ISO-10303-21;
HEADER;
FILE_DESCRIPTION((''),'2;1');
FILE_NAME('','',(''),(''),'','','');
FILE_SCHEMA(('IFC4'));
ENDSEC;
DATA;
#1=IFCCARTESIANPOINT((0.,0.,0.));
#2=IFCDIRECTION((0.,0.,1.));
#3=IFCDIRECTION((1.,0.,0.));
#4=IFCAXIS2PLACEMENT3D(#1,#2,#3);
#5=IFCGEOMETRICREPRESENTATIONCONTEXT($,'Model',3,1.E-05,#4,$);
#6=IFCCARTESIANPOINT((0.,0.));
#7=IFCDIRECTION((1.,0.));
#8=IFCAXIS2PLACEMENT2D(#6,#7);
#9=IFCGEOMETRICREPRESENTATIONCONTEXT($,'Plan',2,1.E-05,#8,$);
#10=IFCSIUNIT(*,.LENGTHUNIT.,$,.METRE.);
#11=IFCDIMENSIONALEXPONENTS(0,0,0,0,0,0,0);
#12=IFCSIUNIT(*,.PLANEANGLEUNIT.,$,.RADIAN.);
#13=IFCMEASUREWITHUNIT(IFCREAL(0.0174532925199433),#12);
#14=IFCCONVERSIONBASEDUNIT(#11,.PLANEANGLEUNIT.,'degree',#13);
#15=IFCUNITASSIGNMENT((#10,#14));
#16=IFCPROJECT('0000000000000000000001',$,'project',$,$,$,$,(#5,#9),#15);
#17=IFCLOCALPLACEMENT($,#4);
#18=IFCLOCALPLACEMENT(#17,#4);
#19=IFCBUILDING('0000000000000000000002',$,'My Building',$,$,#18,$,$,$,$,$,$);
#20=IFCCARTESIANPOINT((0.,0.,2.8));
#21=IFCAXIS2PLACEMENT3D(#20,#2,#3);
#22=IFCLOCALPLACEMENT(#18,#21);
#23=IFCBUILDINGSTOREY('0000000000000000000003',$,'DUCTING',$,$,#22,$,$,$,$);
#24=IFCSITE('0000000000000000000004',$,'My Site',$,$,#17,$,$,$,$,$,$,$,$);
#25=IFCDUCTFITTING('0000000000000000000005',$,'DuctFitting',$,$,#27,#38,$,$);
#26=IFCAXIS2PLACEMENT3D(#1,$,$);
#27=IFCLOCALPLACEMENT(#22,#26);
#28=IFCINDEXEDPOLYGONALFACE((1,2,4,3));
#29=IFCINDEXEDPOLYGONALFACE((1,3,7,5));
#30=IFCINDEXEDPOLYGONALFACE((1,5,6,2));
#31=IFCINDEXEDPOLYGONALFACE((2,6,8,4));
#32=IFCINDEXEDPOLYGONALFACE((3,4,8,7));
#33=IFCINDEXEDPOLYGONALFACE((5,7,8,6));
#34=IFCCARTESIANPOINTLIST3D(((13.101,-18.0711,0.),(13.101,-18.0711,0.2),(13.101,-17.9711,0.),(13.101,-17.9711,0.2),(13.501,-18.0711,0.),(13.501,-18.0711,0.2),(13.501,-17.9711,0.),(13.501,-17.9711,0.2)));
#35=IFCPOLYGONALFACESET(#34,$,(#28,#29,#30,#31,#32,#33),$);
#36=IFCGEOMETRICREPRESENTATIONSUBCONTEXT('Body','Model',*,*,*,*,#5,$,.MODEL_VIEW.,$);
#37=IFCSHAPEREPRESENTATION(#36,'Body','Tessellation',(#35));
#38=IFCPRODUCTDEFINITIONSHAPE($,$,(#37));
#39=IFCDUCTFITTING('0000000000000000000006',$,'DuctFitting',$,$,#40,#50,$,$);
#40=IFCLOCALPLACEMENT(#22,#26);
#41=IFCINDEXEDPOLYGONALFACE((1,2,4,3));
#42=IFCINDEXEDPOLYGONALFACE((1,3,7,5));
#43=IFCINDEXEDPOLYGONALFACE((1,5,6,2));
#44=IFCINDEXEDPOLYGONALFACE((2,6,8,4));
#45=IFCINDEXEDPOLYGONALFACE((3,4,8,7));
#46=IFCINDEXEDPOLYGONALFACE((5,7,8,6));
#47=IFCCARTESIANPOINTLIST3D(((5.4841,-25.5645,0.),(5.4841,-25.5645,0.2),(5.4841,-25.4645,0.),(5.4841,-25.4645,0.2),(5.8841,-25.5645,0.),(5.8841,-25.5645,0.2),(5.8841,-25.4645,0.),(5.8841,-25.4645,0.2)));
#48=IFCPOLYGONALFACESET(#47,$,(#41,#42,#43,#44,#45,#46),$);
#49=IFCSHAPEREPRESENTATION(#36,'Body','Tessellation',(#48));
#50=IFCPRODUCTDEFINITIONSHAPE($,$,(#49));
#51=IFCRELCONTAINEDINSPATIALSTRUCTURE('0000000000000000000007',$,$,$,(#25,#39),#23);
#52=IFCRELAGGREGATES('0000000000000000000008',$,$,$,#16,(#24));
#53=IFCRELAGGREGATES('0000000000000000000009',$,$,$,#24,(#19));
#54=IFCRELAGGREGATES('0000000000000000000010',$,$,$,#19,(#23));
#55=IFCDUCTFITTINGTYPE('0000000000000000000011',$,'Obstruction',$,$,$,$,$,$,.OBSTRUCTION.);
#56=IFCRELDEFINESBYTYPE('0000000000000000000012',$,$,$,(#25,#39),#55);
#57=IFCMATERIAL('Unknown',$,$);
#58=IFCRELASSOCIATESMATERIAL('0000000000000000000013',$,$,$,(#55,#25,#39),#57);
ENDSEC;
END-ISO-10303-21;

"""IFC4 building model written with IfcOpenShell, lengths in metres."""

from ifc_helpers import new_model, entity, si_unit, converted_unit, frame, origin_with_axes, origin_2d_with_axis, place, context, subcontext, project, spatial, rectangle, extrude, material, material_profile, profile_set, profile_usage, type_object, element, save


model = new_model("IFC4")

# Units and contexts
model_context = context("Model", 3, precision=1e-05, world=origin_with_axes())
plan_context = context("Plan", 2, precision=1e-05, world=origin_2d_with_axis())
body_context = subcontext(model_context, "Body", "Model", "MODEL_VIEW")
ifc_project = project(units=[si_unit("LENGTHUNIT", "METRE"), converted_unit("PLANEANGLEUNIT", "degree", entity("IfcReal", 0.0174532925199433), si_unit("PLANEANGLEUNIT", "RADIAN"), dimensions=[0, 0, 0, 0, 0, 0, 0])], contexts=[model_context, plan_context])

# Site, building, storey
site_placement = place(None, origin_with_axes())
site = spatial("IfcSite", under=ifc_project, at=site_placement, Name="My Site")
building_placement = place(site_placement, origin_with_axes())
building = spatial("IfcBuilding", under=site, at=building_placement, Name="My Building")
storey_placement = place(building_placement, frame((0.0, 0.0, 2.8), z_axis=(0.0, 0.0, 1.0), x_axis=(1.0, 0.0, 0.0)))
storey = spatial("IfcBuildingStorey", under=building, at=storey_placement, Name="DUCTING")

# Shared definitions
ifc_material = material(Name="Unknown")

# Duct fittings
ifc_material_profile_1 = material_profile(ifc_material, rectangle(XDim=0.4, YDim=0.2))
ifc_profile_set_1 = profile_set([ifc_material_profile_1])
duct_fitting_type_1 = type_object("IfcDuctFittingType", Name="Obstruction", PredefinedType="OBSTRUCTION", material=ifc_profile_set_1)
ifc_profile_usage_1 = profile_usage(ifc_profile_set_1, cardinal=5)
duct_fitting_1_placement = place(storey_placement, frame((13.301, -17.9711, 0.1), z_axis=(0.0, -1.0, 0.0), x_axis=(1.0, 0.0, 0.0)))
element("IfcDuctFitting", 1, at=duct_fitting_1_placement, inside=storey, type_object=duct_fitting_type_1, material=ifc_profile_usage_1, Name="DuctFitting", context=body_context, shape_type="SweptSolid", body=[
    extrude(rectangle(XDim=0.4, YDim=0.2), origin_with_axes(), (0.0, 0.0, 1.0), 0.1),
])
ifc_profile_usage_2 = profile_usage(ifc_profile_set_1, cardinal=5)
duct_fitting_2_placement = place(storey_placement, frame((5.6841, -25.5645, 0.1), z_axis=(0.0, 1.0, 0.0), x_axis=(-1.0, 0.0, 0.0)))
element("IfcDuctFitting", 2, at=duct_fitting_2_placement, inside=storey, type_object=duct_fitting_type_1, material=ifc_profile_usage_2, Name="DuctFitting", context=body_context, shape_type="SweptSolid", body=[
    extrude(rectangle(XDim=0.4, YDim=0.2), origin_with_axes(), (0.0, 0.0, 1.0), 0.1),
])

save(model, "model.ifc")
